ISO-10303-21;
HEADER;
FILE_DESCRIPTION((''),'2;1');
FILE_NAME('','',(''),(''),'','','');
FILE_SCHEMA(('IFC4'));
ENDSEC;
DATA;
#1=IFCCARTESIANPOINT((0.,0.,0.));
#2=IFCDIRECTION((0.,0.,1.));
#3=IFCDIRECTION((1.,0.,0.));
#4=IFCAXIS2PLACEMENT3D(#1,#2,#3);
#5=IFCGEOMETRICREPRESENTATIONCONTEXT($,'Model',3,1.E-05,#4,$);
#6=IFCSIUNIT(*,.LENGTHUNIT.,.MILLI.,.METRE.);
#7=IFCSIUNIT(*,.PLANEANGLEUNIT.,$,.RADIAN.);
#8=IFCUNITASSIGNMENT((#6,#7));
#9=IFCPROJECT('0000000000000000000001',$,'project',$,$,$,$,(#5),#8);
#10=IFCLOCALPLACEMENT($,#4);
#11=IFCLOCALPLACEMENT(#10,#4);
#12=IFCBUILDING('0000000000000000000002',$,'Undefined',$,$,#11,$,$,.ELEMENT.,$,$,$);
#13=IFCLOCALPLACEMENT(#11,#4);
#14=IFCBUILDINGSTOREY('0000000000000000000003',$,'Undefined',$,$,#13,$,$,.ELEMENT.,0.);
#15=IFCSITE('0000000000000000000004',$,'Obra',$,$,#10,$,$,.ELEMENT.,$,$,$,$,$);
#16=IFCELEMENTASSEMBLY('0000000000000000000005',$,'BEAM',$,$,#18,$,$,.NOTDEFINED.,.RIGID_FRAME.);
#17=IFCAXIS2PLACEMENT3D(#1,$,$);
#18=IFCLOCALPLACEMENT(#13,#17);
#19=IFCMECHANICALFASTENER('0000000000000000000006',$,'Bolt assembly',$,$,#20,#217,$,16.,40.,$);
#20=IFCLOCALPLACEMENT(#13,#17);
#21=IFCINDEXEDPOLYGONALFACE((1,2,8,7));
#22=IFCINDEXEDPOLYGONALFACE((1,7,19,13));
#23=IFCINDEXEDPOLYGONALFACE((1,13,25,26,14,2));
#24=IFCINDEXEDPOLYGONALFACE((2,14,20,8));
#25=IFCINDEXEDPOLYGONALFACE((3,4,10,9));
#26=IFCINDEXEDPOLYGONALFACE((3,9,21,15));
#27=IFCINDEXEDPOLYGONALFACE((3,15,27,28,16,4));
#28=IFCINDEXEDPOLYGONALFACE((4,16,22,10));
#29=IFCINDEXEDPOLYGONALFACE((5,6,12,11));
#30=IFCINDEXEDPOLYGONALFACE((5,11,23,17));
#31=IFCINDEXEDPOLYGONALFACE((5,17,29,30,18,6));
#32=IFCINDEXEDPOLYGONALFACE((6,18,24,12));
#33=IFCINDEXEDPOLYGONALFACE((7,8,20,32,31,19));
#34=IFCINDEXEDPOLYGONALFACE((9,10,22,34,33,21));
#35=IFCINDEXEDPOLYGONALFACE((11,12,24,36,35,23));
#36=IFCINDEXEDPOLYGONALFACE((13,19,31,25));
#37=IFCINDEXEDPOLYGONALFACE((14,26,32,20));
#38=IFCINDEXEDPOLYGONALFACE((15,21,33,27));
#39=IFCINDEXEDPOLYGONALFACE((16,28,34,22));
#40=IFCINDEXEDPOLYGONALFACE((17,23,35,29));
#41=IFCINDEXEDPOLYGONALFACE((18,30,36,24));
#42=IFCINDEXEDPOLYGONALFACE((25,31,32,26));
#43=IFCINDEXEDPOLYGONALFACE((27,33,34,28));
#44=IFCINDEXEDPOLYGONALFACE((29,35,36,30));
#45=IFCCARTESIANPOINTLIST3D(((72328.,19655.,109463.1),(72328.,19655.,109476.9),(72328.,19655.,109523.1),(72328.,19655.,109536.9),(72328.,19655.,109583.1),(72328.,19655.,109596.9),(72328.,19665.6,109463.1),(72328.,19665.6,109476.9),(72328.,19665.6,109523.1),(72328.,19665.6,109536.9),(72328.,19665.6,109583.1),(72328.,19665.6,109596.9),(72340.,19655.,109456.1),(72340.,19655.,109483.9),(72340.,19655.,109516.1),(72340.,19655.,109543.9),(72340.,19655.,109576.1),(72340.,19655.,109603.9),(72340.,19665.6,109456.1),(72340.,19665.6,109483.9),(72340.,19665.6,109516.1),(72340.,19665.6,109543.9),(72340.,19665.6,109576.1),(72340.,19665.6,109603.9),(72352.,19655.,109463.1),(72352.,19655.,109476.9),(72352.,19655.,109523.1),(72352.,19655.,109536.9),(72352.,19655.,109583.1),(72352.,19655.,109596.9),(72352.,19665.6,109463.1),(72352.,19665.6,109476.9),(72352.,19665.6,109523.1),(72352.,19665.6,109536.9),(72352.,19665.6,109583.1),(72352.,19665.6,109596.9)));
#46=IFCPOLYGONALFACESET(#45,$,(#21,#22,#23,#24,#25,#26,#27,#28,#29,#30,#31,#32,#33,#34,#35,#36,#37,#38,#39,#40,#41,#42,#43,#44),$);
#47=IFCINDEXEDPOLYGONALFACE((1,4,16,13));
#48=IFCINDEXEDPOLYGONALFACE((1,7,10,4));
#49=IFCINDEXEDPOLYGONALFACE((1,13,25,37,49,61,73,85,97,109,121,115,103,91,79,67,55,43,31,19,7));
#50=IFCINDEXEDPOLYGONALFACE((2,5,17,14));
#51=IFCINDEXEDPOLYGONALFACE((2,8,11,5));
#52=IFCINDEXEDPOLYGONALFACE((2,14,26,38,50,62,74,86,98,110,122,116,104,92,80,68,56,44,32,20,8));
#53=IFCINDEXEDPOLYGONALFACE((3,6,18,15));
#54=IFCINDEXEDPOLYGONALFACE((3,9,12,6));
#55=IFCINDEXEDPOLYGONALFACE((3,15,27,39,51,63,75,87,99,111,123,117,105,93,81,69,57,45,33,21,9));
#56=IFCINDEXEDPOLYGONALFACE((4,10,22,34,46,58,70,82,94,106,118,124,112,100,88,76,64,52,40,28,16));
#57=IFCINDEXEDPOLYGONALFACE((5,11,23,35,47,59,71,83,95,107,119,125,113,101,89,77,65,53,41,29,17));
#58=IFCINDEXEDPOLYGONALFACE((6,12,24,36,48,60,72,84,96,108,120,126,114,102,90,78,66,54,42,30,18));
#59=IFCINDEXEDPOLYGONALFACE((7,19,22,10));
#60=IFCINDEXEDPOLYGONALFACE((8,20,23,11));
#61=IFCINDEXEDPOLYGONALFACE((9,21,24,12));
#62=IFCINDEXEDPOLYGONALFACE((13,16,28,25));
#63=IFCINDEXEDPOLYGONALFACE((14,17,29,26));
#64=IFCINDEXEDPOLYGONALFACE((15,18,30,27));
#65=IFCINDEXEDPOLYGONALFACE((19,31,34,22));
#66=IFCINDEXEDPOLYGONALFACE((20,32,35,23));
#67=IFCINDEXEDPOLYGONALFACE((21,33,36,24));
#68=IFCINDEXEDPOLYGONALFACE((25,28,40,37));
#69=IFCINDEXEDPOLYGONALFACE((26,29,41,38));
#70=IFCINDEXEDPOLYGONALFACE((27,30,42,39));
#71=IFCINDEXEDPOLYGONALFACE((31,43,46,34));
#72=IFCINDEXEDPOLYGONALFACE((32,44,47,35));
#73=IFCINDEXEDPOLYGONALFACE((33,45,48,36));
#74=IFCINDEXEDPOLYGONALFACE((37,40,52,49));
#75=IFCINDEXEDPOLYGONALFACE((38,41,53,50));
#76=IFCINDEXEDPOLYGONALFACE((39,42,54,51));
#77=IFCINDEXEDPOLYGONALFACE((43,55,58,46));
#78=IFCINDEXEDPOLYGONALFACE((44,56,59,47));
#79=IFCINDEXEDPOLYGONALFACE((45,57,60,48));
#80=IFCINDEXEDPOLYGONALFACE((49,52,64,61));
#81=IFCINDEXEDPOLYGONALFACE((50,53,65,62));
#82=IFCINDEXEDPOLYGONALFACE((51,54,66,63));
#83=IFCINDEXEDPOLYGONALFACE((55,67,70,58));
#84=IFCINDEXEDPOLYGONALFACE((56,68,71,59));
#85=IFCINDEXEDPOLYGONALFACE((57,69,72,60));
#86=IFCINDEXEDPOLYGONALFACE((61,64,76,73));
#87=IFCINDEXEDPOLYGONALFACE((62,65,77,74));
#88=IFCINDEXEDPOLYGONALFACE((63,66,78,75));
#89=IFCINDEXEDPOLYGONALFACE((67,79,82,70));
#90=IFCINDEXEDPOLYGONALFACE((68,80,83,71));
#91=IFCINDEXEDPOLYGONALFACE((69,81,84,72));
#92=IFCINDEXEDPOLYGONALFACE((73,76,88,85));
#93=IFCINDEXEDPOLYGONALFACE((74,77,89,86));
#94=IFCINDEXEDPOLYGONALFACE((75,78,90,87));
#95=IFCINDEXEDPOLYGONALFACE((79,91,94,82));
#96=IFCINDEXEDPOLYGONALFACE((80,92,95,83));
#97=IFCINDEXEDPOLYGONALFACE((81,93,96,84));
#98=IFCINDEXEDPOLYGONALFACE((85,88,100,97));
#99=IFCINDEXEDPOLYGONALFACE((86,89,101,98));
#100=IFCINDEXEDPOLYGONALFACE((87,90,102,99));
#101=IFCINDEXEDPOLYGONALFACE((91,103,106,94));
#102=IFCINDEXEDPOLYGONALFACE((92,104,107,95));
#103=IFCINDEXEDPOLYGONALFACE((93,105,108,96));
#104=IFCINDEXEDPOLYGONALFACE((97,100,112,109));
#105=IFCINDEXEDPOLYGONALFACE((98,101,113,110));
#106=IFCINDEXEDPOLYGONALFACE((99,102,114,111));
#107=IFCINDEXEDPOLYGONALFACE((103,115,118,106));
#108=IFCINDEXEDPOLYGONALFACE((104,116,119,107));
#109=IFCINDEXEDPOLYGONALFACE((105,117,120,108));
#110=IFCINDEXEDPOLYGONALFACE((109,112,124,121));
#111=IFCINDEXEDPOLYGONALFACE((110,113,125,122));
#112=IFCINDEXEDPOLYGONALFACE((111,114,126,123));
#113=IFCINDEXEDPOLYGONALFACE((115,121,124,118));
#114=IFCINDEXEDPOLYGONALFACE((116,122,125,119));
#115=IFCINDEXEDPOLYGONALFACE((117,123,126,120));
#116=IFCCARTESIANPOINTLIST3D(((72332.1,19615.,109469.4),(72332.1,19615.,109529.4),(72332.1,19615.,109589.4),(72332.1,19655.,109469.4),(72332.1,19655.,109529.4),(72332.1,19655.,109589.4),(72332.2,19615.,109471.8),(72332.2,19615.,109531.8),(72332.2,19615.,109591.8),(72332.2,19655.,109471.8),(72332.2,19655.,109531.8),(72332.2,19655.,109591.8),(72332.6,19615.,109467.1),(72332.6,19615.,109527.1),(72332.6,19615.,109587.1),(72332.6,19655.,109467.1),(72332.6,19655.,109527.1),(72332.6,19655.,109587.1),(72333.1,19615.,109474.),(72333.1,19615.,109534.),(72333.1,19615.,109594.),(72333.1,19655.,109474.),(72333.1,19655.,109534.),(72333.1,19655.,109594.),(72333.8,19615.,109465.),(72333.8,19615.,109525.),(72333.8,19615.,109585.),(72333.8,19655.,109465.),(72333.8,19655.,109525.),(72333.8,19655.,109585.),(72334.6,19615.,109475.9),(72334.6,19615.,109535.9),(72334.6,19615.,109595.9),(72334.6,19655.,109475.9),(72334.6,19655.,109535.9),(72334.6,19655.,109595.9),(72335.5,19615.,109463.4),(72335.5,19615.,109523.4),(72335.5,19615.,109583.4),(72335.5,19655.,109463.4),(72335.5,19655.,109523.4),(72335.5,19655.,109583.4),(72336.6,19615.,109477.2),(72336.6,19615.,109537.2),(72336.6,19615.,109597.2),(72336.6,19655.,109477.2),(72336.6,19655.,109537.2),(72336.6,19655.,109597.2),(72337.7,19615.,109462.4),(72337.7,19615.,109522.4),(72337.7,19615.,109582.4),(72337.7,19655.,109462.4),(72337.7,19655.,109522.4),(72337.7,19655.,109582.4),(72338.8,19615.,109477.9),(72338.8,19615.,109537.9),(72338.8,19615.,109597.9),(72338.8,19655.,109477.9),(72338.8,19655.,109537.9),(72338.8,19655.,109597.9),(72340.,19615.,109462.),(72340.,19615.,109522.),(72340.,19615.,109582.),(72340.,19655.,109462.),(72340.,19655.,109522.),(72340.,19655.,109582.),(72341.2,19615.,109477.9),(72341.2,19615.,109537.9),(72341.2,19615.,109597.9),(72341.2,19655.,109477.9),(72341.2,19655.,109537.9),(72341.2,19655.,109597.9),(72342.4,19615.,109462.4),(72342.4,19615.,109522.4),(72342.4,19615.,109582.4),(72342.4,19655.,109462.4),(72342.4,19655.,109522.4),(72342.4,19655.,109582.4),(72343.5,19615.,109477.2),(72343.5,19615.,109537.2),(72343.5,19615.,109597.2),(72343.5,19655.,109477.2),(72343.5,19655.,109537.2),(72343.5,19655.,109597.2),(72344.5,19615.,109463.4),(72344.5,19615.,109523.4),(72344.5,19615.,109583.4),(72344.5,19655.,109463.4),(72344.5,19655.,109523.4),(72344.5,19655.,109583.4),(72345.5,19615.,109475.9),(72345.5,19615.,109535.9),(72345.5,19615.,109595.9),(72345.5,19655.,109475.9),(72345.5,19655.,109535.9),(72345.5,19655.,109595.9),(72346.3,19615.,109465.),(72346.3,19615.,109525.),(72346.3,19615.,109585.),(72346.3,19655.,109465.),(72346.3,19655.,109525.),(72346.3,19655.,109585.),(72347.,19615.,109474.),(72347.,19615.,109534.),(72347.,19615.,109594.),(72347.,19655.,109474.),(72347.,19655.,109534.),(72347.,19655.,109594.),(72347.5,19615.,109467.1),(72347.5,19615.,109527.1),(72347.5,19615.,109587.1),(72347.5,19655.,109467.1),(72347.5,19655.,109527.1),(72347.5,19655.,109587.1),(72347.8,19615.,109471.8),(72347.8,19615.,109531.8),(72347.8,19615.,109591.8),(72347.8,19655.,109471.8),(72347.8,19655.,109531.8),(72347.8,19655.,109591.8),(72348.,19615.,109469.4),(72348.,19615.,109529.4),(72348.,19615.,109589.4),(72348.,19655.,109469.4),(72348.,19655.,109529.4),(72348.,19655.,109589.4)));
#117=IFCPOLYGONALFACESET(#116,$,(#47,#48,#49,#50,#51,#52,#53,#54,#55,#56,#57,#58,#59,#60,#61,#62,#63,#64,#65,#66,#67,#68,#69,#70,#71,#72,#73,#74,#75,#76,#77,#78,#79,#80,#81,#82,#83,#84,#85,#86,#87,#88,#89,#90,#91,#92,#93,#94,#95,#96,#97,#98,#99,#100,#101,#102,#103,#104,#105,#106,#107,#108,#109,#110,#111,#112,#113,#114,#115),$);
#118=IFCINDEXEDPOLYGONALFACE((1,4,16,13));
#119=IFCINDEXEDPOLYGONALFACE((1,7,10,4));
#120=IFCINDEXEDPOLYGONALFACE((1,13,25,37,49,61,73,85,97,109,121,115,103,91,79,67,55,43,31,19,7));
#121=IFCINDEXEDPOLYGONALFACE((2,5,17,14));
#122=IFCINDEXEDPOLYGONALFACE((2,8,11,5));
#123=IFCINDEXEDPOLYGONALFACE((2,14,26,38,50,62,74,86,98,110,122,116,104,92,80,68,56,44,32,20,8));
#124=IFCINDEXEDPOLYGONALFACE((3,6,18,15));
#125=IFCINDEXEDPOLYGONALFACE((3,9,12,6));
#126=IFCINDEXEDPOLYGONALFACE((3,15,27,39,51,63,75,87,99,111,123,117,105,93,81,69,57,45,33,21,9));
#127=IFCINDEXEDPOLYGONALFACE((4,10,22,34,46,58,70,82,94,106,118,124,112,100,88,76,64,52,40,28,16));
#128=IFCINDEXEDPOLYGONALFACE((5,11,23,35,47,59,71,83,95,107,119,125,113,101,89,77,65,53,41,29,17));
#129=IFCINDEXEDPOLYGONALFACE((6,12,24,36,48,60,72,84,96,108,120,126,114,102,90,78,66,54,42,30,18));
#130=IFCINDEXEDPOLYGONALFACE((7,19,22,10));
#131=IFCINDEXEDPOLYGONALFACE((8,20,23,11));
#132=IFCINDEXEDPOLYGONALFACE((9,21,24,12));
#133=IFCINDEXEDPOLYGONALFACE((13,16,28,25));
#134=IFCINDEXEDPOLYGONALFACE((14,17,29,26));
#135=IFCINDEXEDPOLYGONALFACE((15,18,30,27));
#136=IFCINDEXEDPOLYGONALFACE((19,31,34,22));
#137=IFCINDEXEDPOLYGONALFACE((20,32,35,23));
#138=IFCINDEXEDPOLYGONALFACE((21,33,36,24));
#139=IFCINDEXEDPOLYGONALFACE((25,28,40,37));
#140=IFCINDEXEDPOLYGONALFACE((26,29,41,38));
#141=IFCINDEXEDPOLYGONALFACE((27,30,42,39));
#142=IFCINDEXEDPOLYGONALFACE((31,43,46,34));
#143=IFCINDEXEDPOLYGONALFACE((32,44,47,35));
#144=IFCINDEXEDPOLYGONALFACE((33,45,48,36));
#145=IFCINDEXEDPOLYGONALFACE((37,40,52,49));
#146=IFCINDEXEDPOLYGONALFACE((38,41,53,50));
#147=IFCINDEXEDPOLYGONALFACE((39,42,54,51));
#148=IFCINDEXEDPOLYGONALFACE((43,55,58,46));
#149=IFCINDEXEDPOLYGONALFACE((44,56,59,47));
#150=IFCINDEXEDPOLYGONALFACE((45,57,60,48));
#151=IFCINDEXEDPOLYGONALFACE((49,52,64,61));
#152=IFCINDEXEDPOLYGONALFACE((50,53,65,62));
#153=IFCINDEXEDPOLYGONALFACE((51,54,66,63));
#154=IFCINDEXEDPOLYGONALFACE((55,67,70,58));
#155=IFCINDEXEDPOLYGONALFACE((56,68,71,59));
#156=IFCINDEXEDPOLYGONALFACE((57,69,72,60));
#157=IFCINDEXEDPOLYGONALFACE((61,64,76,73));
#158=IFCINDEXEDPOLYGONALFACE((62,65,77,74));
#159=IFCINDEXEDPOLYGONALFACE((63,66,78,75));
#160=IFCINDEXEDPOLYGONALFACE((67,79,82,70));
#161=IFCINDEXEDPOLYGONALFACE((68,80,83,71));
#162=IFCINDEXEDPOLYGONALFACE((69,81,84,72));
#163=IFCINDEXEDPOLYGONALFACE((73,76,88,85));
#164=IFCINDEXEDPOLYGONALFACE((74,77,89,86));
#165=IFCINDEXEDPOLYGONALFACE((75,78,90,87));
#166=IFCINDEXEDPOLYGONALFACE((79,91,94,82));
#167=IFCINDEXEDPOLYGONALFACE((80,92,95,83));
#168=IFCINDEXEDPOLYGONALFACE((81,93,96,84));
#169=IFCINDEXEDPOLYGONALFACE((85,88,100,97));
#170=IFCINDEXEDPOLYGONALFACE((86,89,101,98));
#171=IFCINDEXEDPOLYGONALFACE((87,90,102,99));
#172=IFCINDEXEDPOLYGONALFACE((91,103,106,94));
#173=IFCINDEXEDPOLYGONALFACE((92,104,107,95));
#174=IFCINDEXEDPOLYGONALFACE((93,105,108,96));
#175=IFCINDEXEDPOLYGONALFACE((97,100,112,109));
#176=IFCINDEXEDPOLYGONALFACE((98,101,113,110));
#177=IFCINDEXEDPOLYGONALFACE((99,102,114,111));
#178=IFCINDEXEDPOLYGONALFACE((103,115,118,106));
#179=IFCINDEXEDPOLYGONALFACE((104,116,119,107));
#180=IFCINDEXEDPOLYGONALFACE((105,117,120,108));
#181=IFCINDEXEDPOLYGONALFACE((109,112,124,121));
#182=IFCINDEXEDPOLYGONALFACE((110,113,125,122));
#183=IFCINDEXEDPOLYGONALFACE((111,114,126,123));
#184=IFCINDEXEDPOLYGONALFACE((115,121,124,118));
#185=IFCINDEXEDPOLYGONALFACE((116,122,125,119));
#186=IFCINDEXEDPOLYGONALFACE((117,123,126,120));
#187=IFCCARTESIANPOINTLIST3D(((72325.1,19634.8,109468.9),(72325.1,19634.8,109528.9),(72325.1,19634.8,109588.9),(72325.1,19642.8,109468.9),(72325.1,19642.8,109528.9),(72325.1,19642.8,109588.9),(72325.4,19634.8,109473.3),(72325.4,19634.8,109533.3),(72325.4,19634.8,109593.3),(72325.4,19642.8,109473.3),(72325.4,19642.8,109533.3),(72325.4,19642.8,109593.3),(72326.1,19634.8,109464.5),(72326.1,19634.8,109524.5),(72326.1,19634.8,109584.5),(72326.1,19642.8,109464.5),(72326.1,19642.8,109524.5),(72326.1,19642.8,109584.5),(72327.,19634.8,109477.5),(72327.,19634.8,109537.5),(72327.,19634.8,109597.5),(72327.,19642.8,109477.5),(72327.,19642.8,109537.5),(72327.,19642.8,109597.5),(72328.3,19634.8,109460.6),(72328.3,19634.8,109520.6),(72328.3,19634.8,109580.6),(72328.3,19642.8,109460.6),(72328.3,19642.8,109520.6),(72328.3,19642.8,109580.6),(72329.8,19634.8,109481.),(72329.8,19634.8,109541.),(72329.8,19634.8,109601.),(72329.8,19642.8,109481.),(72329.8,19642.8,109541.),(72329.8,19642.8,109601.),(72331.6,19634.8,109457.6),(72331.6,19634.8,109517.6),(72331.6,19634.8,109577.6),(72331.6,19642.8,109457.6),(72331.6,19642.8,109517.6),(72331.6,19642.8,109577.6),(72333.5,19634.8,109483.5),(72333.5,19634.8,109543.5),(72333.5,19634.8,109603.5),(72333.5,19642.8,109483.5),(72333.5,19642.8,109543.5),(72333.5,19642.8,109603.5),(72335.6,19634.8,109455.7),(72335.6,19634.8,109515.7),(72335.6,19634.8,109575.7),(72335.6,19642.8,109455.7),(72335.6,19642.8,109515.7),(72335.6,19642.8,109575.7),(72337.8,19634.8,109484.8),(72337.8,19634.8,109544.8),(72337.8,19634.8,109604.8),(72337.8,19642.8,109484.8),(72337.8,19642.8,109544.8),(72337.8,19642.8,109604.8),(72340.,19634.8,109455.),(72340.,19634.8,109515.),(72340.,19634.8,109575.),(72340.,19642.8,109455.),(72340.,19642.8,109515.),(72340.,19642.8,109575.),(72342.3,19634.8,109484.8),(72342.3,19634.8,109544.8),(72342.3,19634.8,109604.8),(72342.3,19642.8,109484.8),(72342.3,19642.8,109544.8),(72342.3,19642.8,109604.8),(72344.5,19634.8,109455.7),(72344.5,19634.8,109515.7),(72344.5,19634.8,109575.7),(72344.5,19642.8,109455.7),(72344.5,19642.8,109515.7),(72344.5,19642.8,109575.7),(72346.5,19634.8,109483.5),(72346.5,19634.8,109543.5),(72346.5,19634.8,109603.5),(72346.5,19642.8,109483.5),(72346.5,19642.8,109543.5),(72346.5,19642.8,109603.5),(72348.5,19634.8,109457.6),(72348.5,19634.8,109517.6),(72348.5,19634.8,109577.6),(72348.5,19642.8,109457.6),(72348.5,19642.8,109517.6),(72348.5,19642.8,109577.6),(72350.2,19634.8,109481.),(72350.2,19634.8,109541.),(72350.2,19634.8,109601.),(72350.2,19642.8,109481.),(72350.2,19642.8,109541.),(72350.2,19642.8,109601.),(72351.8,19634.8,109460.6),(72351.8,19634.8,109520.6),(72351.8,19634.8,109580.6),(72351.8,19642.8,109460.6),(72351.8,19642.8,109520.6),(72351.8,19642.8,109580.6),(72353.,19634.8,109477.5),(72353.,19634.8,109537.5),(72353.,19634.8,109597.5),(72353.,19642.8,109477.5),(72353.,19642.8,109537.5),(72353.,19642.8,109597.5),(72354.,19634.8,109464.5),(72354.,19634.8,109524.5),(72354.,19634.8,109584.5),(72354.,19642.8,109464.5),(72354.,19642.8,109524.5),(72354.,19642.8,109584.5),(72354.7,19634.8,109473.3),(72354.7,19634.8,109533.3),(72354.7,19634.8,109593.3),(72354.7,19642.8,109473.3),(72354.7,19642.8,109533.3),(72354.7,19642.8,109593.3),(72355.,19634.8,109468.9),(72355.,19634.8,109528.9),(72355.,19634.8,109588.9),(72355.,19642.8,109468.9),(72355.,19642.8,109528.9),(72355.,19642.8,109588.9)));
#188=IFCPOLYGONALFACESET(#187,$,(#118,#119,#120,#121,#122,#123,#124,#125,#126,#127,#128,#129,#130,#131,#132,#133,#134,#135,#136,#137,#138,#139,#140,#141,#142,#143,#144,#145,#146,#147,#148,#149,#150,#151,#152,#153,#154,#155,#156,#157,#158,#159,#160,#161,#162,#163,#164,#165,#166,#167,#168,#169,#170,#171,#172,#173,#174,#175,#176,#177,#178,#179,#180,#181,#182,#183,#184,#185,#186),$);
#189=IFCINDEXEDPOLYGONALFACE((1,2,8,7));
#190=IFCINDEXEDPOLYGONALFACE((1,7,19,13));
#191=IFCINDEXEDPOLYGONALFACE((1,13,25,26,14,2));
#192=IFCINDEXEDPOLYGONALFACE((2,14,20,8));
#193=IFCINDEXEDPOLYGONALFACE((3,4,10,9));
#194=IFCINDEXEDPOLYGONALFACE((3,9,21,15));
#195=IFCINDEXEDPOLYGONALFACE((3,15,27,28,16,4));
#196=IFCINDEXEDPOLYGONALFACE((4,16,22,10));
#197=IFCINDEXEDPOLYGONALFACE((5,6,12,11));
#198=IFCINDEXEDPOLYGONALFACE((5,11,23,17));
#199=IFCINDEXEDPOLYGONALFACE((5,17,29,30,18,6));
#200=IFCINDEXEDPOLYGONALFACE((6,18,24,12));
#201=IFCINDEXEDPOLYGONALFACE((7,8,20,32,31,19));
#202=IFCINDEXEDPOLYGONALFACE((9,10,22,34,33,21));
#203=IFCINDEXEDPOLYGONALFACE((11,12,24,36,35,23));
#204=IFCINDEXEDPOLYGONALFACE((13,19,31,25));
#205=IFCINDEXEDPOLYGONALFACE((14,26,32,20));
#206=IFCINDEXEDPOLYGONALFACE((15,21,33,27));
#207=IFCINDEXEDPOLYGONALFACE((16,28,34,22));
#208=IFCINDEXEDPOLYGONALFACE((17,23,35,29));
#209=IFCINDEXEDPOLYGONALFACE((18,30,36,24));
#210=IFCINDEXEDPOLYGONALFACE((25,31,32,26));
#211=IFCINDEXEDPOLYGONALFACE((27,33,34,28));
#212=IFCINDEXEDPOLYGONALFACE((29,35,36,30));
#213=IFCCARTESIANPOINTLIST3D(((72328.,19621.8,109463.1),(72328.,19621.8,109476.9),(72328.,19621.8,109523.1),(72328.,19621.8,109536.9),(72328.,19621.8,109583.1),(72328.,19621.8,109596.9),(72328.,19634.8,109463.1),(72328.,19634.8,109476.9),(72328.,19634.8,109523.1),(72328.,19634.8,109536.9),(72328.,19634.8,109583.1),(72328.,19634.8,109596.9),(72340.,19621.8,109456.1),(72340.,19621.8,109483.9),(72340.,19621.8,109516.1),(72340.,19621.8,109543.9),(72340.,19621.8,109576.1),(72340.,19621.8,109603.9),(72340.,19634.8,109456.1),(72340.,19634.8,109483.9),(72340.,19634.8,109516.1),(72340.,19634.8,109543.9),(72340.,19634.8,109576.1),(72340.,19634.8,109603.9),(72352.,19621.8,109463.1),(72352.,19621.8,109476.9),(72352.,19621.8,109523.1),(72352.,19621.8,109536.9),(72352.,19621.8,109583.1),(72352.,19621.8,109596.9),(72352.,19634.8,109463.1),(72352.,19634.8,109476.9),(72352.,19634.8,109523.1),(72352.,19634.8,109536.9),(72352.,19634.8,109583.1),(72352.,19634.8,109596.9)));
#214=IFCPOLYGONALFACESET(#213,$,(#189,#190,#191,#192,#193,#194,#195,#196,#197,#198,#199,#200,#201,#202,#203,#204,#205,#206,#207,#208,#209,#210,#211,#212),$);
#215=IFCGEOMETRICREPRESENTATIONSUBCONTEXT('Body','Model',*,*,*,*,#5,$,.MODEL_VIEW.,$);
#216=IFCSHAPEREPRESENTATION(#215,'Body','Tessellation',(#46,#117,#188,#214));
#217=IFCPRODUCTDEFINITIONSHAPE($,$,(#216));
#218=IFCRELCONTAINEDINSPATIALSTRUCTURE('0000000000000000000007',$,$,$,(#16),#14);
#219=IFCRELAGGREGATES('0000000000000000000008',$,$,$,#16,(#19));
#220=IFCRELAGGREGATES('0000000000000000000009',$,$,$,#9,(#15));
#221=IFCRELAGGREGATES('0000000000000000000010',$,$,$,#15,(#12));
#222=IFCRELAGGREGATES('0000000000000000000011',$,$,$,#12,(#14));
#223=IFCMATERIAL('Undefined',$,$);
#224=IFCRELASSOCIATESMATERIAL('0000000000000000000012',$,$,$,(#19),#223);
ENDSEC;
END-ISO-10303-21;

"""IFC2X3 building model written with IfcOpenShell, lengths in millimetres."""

from ifc_helpers import new_model, si_unit, frame, origin_with_axes, origin_2d_with_axis, place, context, subcontext, project, spatial, polyline, circle, outline, extrude, source, transform, mapped, material, element, aggregate, save


model = new_model("IFC2X3")

# Units and contexts
model_context = context("Model", 3, precision=1e-05, world=origin_with_axes())
body_context = subcontext(model_context, "Body", "Model", "MODEL_VIEW")
ifc_project = project(units=[si_unit("LENGTHUNIT", "METRE", prefix="MILLI"), si_unit("PLANEANGLEUNIT", "RADIAN")], contexts=[model_context])

# Site, building, storey
site_placement = place(None, origin_with_axes())
site = spatial("IfcSite", under=ifc_project, at=site_placement, Name="Obra", CompositionType="ELEMENT")
building_placement = place(site_placement, origin_with_axes())
building = spatial("IfcBuilding", under=site, at=building_placement, Name="Undefined", CompositionType="ELEMENT")
storey_placement = place(building_placement, origin_with_axes())
storey = spatial("IfcBuildingStorey", under=building, at=storey_placement, Name="Undefined", CompositionType="ELEMENT", Elevation=0.0)

# Shared definitions
ifc_material_1 = material(Name="Undefined")
shared_shape_1 = source(origin_with_axes(), body_context, "Body", "SweptSolid", [
    extrude(outline(polyline([(13.9, 0.0), (6.9, 12.0), (-6.9, 12.0), (-13.9, 0.0), (-6.9, -12.0), (6.9, -12.0), (13.9, 0.0)])), frame((0.0, -19.7, 0.0), z_axis=(0.0, 1.0, 0.0), x_axis=(1.0, 0.0, 0.0)), (0.0, 0.0, 1.0), 10.6),
    extrude(circle(Radius=8.0, at=origin_2d_with_axis()), frame((0.0, -9.1, 0.0), z_axis=(0.0, 1.0, 0.0), x_axis=(1.0, 0.0, 0.0)), (0.0, 0.0, 1.0), 40.0),
    extrude(circle(Radius=15.0, at=origin_2d_with_axis()), frame((0.0, 3.1, 0.0), z_axis=(0.0, 1.0, 0.0), x_axis=(1.0, 0.0, 0.0)), (0.0, 0.0, 1.0), 8.0),
    extrude(outline(polyline([(13.9, 0.0), (6.9, 12.0), (-6.9, 12.0), (-13.9, 0.0), (-6.9, -12.0), (6.9, -12.0), (13.9, 0.0)])), frame((0.0, 11.1, 0.0), z_axis=(0.0, 1.0, 0.0), x_axis=(1.0, 0.0, 0.0)), (0.0, 0.0, 1.0), 13.0),
])

# Element assembly, mechanical fastener
assembly_1_placement = place(storey_placement, origin_with_axes())
assembly_1 = element("IfcElementAssembly", 1, at=assembly_1_placement, inside=storey, Name="BEAM", AssemblyPlace="NOTDEFINED", PredefinedType="RIGID_FRAME")
mechanical_fastener_1_placement = place(assembly_1_placement, frame((72390.0, 19645.9, 109650.0), z_axis=(-1.0, 0.000126, 0.0), x_axis=(0.0, 0.0, -1.0)))
mechanical_fastener_1 = element("IfcMechanicalFastener", 2, at=mechanical_fastener_1_placement, material=ifc_material_1, Name="Bolt assembly", NominalDiameter=16.0, NominalLength=40.0, context=body_context, shape_type="MappedRepresentation", body=[
    mapped(shared_shape_1, transform((60.0, 0.0, 50.0))),
    mapped(shared_shape_1, transform((120.0, 0.0, 50.0))),
    mapped(shared_shape_1, transform((180.0, 0.0, 50.0))),
])
aggregate(assembly_1, [mechanical_fastener_1])

save(model, "model.ifc")
